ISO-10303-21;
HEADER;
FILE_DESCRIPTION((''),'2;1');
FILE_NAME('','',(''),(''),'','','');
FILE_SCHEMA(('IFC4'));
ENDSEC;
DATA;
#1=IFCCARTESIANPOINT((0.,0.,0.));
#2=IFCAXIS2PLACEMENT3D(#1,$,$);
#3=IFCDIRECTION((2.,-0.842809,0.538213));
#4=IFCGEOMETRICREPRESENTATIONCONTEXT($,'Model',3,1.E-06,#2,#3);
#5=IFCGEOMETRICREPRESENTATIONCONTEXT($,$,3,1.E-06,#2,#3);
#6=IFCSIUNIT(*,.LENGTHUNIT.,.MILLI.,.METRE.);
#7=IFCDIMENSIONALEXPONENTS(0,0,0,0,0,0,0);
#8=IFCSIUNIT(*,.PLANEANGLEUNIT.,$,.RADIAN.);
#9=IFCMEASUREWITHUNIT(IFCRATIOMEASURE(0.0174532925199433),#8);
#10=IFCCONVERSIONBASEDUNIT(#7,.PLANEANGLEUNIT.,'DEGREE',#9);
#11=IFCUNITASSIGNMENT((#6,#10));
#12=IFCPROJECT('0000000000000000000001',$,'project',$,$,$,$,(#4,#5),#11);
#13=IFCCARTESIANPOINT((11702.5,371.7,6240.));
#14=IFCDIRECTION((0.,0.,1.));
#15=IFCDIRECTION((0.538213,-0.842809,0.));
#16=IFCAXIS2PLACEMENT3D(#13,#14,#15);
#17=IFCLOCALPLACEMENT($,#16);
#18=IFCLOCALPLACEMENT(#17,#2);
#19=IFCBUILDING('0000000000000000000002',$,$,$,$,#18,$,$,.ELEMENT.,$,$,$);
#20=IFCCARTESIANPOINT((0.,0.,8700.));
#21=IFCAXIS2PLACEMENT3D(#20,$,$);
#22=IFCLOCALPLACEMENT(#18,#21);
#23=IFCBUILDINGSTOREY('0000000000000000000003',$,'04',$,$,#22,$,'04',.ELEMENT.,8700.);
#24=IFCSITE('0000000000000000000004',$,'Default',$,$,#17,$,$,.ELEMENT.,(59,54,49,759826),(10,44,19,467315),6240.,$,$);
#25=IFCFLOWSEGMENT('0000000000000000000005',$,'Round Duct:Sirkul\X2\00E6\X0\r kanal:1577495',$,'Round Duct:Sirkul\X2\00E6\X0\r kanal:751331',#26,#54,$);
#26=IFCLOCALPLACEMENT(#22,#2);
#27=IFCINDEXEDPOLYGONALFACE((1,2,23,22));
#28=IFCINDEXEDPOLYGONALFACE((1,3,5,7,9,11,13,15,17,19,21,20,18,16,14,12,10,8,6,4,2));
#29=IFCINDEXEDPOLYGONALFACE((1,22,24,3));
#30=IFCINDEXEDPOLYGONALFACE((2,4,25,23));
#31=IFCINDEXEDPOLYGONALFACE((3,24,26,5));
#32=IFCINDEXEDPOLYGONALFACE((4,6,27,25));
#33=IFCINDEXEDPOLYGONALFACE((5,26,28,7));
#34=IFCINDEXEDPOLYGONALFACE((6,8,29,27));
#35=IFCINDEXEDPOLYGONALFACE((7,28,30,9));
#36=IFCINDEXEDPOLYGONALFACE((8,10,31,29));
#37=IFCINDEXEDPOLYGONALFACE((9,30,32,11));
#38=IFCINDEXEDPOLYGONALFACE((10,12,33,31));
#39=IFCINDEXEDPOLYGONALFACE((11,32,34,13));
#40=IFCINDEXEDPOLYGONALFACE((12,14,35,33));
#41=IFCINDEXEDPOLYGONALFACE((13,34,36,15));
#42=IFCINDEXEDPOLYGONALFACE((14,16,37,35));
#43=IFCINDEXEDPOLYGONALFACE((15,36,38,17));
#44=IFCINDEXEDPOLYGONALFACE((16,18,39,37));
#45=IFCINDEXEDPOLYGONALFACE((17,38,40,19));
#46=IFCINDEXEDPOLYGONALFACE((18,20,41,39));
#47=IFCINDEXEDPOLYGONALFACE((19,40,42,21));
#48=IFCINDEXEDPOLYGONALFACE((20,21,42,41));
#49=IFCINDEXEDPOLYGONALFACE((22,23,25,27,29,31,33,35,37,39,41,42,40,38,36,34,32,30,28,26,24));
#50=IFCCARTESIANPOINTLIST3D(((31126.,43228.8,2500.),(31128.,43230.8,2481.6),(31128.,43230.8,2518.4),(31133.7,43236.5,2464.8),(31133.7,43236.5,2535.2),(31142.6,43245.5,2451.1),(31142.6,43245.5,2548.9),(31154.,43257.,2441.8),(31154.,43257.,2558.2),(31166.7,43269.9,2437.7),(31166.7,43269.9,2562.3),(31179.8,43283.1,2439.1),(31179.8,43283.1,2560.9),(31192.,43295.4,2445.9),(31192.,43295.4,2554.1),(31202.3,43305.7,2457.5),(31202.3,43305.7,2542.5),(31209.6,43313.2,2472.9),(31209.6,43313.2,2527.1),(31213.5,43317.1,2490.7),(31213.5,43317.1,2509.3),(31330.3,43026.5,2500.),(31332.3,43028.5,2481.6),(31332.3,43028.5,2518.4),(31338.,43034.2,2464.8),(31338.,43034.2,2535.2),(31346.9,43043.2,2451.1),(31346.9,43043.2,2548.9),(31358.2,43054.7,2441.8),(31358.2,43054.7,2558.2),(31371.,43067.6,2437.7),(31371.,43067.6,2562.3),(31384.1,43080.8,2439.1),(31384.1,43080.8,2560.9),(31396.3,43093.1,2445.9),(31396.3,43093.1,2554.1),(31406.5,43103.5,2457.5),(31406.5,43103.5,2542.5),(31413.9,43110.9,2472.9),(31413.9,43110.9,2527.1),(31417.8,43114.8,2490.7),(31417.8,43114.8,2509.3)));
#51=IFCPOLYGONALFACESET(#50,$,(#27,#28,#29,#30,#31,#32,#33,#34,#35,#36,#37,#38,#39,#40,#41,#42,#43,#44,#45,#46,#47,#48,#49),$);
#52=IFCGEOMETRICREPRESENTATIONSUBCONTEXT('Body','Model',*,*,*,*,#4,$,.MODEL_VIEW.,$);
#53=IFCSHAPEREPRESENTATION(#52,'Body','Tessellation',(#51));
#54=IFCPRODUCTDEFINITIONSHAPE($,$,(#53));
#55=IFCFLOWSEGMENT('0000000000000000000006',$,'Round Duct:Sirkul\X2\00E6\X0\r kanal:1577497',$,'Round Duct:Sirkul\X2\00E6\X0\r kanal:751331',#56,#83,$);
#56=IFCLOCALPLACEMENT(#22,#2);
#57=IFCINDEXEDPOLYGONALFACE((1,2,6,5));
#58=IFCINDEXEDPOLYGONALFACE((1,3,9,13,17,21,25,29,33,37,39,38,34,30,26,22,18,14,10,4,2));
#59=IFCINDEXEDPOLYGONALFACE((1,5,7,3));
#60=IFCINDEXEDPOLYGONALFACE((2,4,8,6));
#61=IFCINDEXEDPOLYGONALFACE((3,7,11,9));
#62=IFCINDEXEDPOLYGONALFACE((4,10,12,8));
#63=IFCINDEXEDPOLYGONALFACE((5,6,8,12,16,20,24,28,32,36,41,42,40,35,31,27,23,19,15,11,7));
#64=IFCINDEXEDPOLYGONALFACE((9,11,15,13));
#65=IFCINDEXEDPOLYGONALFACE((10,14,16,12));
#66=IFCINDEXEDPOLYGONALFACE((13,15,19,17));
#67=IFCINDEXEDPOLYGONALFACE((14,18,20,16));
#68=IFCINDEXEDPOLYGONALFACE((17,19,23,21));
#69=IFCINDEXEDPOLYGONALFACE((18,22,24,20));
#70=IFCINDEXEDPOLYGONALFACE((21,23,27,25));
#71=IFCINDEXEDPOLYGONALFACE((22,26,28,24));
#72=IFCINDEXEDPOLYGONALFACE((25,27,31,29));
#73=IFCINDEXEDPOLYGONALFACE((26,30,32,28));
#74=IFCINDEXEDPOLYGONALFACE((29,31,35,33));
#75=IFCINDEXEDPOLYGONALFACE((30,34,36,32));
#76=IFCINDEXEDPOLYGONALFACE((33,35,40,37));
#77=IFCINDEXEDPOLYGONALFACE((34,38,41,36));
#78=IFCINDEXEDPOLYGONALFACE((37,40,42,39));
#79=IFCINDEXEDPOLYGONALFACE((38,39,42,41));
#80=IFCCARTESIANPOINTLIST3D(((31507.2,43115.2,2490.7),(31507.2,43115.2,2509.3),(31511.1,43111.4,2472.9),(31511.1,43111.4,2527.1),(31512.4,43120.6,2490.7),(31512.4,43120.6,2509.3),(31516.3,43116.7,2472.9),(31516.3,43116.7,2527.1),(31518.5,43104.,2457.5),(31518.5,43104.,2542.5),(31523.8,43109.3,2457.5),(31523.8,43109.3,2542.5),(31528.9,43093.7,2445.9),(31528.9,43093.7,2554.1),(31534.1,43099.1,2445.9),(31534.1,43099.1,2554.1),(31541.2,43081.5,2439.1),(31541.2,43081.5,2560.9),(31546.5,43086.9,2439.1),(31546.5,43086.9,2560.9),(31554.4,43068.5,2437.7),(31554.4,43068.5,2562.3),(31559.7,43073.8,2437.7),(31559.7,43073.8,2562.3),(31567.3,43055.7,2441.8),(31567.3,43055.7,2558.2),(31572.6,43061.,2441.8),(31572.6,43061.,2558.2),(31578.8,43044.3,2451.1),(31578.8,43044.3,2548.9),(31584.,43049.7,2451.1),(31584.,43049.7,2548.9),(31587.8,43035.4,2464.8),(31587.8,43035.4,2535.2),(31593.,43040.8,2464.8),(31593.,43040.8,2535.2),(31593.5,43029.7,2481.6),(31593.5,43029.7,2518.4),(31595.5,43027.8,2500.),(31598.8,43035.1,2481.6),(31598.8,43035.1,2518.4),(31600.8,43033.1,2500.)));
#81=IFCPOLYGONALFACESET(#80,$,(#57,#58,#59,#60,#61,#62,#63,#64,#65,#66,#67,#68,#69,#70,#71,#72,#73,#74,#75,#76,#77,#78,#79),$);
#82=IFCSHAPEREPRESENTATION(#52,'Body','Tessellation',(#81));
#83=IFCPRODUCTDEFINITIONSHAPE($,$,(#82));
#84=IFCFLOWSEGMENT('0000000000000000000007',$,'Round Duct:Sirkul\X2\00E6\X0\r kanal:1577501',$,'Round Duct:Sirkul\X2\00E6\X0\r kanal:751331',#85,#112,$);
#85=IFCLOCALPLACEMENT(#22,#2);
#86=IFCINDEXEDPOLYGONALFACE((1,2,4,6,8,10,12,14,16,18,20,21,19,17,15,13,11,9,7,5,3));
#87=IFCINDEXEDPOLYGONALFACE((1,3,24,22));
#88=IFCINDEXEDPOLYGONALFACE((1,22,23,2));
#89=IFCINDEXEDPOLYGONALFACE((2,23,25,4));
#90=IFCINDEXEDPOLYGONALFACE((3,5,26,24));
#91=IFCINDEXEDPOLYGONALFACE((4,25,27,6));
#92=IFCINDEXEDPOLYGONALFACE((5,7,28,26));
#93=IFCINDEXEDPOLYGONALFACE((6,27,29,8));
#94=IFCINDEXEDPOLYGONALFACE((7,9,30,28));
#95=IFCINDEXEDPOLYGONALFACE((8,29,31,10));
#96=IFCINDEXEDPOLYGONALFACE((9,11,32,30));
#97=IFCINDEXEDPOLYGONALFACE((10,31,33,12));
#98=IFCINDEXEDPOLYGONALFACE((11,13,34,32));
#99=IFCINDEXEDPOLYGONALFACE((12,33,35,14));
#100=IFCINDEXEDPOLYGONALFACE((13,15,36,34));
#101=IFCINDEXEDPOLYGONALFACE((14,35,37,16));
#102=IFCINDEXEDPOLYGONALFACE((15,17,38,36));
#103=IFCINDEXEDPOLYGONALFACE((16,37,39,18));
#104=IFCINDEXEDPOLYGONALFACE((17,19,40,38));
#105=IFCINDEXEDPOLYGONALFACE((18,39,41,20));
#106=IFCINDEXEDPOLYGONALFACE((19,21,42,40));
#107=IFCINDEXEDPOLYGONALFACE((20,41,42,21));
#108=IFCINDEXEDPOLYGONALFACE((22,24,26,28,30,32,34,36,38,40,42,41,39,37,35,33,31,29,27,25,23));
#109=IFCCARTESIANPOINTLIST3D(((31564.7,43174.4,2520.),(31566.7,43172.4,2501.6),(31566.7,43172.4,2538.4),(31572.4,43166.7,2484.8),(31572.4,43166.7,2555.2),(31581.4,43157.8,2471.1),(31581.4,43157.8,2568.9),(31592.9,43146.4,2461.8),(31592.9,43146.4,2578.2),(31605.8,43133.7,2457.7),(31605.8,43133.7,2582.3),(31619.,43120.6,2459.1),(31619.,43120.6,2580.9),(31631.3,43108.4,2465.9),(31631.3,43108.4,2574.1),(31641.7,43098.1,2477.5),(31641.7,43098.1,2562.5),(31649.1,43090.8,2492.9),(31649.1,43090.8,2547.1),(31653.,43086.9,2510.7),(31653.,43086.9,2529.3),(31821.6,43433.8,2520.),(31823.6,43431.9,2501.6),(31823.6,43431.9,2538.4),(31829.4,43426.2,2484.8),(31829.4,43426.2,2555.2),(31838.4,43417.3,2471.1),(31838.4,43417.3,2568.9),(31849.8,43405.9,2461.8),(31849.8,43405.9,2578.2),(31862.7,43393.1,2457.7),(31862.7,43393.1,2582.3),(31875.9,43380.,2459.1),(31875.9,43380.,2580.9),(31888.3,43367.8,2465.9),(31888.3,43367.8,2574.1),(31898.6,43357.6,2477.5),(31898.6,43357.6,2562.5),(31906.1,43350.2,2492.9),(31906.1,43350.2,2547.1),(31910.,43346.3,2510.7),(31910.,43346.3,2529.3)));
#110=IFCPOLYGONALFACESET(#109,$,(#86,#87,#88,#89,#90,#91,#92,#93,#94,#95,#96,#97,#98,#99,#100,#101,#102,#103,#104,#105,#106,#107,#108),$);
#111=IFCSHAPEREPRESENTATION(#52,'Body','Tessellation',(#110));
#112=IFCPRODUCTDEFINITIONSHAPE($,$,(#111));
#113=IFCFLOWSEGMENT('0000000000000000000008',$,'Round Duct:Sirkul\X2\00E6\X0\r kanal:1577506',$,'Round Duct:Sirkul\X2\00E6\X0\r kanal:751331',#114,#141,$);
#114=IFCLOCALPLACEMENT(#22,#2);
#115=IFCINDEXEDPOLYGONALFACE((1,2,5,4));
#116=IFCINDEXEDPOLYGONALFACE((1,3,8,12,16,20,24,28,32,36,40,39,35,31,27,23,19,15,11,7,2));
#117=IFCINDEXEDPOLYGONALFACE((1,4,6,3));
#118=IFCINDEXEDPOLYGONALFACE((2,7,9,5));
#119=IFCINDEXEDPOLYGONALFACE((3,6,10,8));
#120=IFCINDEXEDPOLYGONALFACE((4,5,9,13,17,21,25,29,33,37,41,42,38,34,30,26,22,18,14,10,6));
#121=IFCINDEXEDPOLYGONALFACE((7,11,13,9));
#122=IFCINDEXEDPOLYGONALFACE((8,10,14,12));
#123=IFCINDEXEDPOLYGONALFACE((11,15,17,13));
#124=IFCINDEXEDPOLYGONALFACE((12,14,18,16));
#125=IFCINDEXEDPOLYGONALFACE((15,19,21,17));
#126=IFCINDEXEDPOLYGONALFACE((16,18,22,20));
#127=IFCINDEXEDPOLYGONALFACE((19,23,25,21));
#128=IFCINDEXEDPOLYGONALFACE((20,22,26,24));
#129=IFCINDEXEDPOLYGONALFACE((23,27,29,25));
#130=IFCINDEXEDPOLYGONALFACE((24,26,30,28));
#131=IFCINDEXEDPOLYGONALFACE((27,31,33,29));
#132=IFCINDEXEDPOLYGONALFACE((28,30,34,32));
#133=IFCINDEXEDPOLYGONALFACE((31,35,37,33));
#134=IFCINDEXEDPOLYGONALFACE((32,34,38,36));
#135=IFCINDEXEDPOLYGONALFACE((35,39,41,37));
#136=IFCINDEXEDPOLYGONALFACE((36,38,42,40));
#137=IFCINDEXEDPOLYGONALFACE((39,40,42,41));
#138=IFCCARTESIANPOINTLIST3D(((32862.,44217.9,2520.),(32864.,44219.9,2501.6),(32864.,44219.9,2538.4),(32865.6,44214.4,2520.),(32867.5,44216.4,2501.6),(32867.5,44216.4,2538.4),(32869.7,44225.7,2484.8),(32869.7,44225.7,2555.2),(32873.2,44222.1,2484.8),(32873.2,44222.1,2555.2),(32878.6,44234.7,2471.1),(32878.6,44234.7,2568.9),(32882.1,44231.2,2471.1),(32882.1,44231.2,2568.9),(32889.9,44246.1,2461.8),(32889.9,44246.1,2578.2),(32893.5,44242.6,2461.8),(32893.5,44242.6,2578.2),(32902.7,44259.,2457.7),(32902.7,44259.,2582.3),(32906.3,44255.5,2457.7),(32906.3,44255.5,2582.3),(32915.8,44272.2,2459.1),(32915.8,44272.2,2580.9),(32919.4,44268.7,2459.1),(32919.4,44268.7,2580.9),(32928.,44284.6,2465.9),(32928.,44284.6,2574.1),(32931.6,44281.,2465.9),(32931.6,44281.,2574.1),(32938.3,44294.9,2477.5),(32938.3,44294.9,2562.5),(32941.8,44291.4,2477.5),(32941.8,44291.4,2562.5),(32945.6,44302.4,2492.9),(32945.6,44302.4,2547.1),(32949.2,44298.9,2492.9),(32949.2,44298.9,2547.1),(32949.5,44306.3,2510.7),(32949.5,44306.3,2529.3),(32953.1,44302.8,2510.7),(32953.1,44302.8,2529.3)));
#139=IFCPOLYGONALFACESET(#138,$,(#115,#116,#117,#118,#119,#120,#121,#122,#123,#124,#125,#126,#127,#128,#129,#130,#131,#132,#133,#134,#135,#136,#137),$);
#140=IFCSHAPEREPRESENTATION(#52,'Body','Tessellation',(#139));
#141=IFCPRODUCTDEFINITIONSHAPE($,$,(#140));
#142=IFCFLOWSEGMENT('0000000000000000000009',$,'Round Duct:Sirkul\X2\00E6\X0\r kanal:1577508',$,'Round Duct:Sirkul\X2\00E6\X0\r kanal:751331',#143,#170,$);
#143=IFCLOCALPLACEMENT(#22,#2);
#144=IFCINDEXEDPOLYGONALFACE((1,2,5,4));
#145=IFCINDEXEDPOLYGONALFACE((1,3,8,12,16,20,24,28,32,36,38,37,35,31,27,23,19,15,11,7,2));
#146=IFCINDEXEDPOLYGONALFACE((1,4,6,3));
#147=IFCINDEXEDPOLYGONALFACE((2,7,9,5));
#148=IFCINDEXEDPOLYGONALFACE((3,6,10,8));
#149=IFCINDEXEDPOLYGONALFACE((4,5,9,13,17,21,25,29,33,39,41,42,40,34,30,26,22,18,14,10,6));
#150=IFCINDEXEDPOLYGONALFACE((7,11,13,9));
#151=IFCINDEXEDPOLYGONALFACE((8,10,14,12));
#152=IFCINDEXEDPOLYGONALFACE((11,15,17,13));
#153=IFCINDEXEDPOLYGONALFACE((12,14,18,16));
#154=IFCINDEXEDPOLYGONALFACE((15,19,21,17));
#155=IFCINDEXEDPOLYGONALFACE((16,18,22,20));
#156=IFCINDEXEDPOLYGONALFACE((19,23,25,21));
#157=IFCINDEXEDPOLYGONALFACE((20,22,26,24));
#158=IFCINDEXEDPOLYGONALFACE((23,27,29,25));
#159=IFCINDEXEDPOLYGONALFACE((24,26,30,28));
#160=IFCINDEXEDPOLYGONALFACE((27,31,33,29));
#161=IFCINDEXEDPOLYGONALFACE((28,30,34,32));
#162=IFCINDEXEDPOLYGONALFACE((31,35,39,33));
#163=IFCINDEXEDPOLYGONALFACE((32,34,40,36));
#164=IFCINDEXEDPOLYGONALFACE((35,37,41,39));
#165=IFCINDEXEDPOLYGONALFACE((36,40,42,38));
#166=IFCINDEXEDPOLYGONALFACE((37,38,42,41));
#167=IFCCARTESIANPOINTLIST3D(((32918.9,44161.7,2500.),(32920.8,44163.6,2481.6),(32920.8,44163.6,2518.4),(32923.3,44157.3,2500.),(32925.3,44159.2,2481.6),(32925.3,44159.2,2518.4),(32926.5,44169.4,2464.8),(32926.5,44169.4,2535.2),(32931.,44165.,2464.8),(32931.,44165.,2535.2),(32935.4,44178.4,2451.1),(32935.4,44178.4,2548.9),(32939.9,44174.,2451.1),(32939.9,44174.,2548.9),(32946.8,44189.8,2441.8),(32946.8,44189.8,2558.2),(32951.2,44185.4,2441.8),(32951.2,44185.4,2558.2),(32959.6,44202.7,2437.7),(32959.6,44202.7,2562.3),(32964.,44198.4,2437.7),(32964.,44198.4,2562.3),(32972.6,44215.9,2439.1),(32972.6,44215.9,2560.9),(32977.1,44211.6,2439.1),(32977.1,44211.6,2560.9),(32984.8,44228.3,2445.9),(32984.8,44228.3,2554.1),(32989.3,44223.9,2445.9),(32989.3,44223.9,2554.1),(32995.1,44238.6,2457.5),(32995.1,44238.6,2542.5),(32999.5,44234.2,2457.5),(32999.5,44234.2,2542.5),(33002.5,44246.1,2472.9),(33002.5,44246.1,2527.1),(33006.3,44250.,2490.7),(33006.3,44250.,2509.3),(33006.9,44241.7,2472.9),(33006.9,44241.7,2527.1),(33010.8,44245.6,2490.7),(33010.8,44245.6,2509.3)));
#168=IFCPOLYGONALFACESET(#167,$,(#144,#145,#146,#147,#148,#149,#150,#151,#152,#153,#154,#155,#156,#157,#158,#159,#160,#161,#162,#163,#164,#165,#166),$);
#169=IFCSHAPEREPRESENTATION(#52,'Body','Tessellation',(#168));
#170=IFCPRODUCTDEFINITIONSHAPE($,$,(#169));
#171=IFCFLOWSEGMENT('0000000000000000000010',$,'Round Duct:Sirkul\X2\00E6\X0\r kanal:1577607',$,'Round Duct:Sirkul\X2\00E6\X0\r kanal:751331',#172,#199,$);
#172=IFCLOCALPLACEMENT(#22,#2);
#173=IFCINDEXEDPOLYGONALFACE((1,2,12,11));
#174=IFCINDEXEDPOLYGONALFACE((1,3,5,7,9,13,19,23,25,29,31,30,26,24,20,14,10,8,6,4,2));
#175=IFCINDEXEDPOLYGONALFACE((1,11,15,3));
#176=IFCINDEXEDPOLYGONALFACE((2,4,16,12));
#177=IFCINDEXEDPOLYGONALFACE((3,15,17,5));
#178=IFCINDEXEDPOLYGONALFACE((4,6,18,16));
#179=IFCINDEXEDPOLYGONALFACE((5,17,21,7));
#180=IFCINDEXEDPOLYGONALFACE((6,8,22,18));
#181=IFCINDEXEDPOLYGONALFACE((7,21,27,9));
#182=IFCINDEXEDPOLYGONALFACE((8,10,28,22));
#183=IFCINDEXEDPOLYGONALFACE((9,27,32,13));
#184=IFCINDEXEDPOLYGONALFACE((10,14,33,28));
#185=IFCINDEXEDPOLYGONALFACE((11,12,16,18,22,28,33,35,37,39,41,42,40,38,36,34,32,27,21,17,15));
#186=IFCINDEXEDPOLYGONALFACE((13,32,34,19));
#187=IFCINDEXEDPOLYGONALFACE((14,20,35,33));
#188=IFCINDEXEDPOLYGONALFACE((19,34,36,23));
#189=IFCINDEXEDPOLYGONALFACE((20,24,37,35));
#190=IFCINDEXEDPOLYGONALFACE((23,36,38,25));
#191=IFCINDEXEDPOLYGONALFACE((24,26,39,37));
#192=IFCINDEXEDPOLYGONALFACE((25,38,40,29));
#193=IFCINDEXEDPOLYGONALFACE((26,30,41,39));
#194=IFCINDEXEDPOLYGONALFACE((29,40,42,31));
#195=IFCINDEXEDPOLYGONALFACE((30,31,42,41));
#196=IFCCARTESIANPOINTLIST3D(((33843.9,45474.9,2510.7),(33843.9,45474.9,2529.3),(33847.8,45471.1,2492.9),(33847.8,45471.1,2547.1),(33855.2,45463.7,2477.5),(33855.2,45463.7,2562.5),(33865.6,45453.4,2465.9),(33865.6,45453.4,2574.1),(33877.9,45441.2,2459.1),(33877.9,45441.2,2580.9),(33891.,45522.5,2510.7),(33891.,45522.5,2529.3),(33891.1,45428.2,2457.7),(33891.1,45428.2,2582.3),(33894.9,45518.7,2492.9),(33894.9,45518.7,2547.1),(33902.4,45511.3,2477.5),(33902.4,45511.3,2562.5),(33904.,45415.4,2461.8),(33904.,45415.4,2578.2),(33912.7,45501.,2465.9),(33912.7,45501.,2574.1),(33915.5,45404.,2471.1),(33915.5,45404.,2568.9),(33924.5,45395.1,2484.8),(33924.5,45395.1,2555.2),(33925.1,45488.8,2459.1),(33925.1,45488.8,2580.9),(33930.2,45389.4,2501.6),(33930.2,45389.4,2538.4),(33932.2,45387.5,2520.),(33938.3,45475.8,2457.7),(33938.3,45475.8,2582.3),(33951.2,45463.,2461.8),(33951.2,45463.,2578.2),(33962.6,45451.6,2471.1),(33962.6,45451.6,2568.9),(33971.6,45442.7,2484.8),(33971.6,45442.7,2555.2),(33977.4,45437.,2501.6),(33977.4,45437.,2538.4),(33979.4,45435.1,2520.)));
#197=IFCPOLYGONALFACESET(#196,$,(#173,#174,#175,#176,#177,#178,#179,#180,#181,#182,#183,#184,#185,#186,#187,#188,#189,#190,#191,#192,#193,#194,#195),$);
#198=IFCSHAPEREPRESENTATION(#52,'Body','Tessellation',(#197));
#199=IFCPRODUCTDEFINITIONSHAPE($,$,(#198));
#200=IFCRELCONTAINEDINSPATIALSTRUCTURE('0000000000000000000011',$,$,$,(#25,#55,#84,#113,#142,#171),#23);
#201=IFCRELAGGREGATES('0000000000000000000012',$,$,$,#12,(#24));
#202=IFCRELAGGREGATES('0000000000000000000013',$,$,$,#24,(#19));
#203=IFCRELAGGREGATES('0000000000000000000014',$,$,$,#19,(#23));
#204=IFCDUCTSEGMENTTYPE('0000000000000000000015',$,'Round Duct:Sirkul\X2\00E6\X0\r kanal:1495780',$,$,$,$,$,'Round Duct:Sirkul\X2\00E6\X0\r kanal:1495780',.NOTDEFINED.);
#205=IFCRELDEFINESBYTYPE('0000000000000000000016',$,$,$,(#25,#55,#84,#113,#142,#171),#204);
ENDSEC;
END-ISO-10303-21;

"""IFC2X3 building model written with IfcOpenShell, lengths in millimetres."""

from ifc_helpers import new_model, entity, si_unit, converted_unit, direction, frame, origin, origin_2d_with_axis, place, context, subcontext, project, spatial, circle, extrude, type_object, element, save


model = new_model("IFC2X3")

# Units and contexts
model_context = context("Model", 3, precision=1e-06, world=origin(), true_north=direction((2.0, -0.842809, 0.538213)))
context_of_model = context(None, 3, precision=1e-06, world=origin(), true_north=direction((2.0, -0.842809, 0.538213)))
body_context = subcontext(model_context, "Body", "Model", "MODEL_VIEW")
ifc_project = project(units=[si_unit("LENGTHUNIT", "METRE", prefix="MILLI"), converted_unit("PLANEANGLEUNIT", "DEGREE", entity("IfcRatioMeasure", 0.0174532925199433), si_unit("PLANEANGLEUNIT", "RADIAN"), dimensions=[0, 0, 0, 0, 0, 0, 0])], contexts=[model_context, context_of_model])

# Site, building, storey
site_placement = place(None, frame((11702.5, 371.7, 6240.0), z_axis=(0.0, 0.0, 1.0), x_axis=(0.538213, -0.842809, 0.0)))
site = spatial("IfcSite", under=ifc_project, at=site_placement, Name="Default", CompositionType="ELEMENT", RefLatitude=(59, 54, 49, 759826), RefLongitude=(10, 44, 19, 467315), RefElevation=6240.0)
building_placement = place(site_placement, origin())
building = spatial("IfcBuilding", under=site, at=building_placement, CompositionType="ELEMENT")
storey_placement = place(building_placement, frame((0.0, 0.0, 8700.0)))
storey = spatial("IfcBuildingStorey", under=building, at=storey_placement, Name="04", LongName="04", CompositionType="ELEMENT", Elevation=8700.0)

# Flow segments
duct_segment_type = type_object("IfcDuctSegmentType", Name="Round Duct:Sirkulær kanal:1495780", ElementType="Round Duct:Sirkulær kanal:1495780", PredefinedType="NOTDEFINED")
flow_segment_1_placement = place(storey_placement, origin())
element("IfcFlowSegment", 1, at=flow_segment_1_placement, inside=storey, type_object=duct_segment_type, Name="Round Duct:Sirkulær kanal:1577495", ObjectType="Round Duct:Sirkulær kanal:751331", context=body_context, shape_type="SweptSolid", body=[
    extrude(circle(Radius=62.5, at=origin_2d_with_axis()), frame((31374.3, 43070.9, 2500.0), z_axis=(-0.710554, 0.703643, 0.0), x_axis=(-0.703643, -0.710554, 0.0)), (0.0, 0.0, 1.0), 287.5),
])
flow_segment_2_placement = place(storey_placement, origin())
element("IfcFlowSegment", 2, at=flow_segment_2_placement, inside=storey, type_object=duct_segment_type, Name="Round Duct:Sirkulær kanal:1577497", ObjectType="Round Duct:Sirkulær kanal:751331", context=body_context, shape_type="SweptSolid", body=[
    extrude(circle(Radius=62.5, at=origin_2d_with_axis()), frame((31551.1, 43071.8, 2500.0), z_axis=(0.703643, 0.710554, 0.0), x_axis=(0.710554, -0.703643, 0.0)), (0.0, 0.0, 1.0), 7.5),
])
flow_segment_3_placement = place(storey_placement, origin())
element("IfcFlowSegment", 3, at=flow_segment_3_placement, inside=storey, type_object=duct_segment_type, Name="Round Duct:Sirkulær kanal:1577501", ObjectType="Round Duct:Sirkulær kanal:751331", context=body_context, shape_type="SweptSolid", body=[
    extrude(circle(Radius=62.5, at=origin_2d_with_axis()), frame((31609.1, 43130.4, 2520.0), z_axis=(0.703643, 0.710554, 0.0), x_axis=(-0.710554, 0.703643, 0.0)), (0.0, 0.0, 1.0), 365.1),
])
flow_segment_4_placement = place(storey_placement, origin())
element("IfcFlowSegment", 4, at=flow_segment_4_placement, inside=storey, type_object=duct_segment_type, Name="Round Duct:Sirkulær kanal:1577506", ObjectType="Round Duct:Sirkulær kanal:751331", context=body_context, shape_type="SweptSolid", body=[
    extrude(circle(Radius=62.5, at=origin_2d_with_axis()), frame((32906.0, 44262.4, 2520.0), z_axis=(0.710554, -0.703643, 0.0), x_axis=(-0.703643, -0.710554, 0.0)), (0.0, 0.0, 1.0), 5.0),
])
flow_segment_5_placement = place(storey_placement, origin())
element("IfcFlowSegment", 5, at=flow_segment_5_placement, inside=storey, type_object=duct_segment_type, Name="Round Duct:Sirkulær kanal:1577508", ObjectType="Round Duct:Sirkulær kanal:751331", context=body_context, shape_type="SweptSolid", body=[
    extrude(circle(Radius=62.5, at=origin_2d_with_axis()), frame((32967.3, 44201.7, 2500.0), z_axis=(-0.710554, 0.703643, 0.0), x_axis=(-0.703643, -0.710554, 0.0)), (0.0, 0.0, 1.0), 6.2),
])
flow_segment_6_placement = place(storey_placement, origin())
element("IfcFlowSegment", 6, at=flow_segment_6_placement, inside=storey, type_object=duct_segment_type, Name="Round Duct:Sirkulær kanal:1577607", ObjectType="Round Duct:Sirkulær kanal:751331", context=body_context, shape_type="SweptSolid", body=[
    extrude(circle(Radius=62.5, at=origin_2d_with_axis()), frame((33887.8, 45431.4, 2520.0), z_axis=(0.703643, 0.710554, 0.0), x_axis=(0.710554, -0.703643, 0.0)), (0.0, 0.0, 1.0), 67.0),
])

save(model, "model.ifc")
